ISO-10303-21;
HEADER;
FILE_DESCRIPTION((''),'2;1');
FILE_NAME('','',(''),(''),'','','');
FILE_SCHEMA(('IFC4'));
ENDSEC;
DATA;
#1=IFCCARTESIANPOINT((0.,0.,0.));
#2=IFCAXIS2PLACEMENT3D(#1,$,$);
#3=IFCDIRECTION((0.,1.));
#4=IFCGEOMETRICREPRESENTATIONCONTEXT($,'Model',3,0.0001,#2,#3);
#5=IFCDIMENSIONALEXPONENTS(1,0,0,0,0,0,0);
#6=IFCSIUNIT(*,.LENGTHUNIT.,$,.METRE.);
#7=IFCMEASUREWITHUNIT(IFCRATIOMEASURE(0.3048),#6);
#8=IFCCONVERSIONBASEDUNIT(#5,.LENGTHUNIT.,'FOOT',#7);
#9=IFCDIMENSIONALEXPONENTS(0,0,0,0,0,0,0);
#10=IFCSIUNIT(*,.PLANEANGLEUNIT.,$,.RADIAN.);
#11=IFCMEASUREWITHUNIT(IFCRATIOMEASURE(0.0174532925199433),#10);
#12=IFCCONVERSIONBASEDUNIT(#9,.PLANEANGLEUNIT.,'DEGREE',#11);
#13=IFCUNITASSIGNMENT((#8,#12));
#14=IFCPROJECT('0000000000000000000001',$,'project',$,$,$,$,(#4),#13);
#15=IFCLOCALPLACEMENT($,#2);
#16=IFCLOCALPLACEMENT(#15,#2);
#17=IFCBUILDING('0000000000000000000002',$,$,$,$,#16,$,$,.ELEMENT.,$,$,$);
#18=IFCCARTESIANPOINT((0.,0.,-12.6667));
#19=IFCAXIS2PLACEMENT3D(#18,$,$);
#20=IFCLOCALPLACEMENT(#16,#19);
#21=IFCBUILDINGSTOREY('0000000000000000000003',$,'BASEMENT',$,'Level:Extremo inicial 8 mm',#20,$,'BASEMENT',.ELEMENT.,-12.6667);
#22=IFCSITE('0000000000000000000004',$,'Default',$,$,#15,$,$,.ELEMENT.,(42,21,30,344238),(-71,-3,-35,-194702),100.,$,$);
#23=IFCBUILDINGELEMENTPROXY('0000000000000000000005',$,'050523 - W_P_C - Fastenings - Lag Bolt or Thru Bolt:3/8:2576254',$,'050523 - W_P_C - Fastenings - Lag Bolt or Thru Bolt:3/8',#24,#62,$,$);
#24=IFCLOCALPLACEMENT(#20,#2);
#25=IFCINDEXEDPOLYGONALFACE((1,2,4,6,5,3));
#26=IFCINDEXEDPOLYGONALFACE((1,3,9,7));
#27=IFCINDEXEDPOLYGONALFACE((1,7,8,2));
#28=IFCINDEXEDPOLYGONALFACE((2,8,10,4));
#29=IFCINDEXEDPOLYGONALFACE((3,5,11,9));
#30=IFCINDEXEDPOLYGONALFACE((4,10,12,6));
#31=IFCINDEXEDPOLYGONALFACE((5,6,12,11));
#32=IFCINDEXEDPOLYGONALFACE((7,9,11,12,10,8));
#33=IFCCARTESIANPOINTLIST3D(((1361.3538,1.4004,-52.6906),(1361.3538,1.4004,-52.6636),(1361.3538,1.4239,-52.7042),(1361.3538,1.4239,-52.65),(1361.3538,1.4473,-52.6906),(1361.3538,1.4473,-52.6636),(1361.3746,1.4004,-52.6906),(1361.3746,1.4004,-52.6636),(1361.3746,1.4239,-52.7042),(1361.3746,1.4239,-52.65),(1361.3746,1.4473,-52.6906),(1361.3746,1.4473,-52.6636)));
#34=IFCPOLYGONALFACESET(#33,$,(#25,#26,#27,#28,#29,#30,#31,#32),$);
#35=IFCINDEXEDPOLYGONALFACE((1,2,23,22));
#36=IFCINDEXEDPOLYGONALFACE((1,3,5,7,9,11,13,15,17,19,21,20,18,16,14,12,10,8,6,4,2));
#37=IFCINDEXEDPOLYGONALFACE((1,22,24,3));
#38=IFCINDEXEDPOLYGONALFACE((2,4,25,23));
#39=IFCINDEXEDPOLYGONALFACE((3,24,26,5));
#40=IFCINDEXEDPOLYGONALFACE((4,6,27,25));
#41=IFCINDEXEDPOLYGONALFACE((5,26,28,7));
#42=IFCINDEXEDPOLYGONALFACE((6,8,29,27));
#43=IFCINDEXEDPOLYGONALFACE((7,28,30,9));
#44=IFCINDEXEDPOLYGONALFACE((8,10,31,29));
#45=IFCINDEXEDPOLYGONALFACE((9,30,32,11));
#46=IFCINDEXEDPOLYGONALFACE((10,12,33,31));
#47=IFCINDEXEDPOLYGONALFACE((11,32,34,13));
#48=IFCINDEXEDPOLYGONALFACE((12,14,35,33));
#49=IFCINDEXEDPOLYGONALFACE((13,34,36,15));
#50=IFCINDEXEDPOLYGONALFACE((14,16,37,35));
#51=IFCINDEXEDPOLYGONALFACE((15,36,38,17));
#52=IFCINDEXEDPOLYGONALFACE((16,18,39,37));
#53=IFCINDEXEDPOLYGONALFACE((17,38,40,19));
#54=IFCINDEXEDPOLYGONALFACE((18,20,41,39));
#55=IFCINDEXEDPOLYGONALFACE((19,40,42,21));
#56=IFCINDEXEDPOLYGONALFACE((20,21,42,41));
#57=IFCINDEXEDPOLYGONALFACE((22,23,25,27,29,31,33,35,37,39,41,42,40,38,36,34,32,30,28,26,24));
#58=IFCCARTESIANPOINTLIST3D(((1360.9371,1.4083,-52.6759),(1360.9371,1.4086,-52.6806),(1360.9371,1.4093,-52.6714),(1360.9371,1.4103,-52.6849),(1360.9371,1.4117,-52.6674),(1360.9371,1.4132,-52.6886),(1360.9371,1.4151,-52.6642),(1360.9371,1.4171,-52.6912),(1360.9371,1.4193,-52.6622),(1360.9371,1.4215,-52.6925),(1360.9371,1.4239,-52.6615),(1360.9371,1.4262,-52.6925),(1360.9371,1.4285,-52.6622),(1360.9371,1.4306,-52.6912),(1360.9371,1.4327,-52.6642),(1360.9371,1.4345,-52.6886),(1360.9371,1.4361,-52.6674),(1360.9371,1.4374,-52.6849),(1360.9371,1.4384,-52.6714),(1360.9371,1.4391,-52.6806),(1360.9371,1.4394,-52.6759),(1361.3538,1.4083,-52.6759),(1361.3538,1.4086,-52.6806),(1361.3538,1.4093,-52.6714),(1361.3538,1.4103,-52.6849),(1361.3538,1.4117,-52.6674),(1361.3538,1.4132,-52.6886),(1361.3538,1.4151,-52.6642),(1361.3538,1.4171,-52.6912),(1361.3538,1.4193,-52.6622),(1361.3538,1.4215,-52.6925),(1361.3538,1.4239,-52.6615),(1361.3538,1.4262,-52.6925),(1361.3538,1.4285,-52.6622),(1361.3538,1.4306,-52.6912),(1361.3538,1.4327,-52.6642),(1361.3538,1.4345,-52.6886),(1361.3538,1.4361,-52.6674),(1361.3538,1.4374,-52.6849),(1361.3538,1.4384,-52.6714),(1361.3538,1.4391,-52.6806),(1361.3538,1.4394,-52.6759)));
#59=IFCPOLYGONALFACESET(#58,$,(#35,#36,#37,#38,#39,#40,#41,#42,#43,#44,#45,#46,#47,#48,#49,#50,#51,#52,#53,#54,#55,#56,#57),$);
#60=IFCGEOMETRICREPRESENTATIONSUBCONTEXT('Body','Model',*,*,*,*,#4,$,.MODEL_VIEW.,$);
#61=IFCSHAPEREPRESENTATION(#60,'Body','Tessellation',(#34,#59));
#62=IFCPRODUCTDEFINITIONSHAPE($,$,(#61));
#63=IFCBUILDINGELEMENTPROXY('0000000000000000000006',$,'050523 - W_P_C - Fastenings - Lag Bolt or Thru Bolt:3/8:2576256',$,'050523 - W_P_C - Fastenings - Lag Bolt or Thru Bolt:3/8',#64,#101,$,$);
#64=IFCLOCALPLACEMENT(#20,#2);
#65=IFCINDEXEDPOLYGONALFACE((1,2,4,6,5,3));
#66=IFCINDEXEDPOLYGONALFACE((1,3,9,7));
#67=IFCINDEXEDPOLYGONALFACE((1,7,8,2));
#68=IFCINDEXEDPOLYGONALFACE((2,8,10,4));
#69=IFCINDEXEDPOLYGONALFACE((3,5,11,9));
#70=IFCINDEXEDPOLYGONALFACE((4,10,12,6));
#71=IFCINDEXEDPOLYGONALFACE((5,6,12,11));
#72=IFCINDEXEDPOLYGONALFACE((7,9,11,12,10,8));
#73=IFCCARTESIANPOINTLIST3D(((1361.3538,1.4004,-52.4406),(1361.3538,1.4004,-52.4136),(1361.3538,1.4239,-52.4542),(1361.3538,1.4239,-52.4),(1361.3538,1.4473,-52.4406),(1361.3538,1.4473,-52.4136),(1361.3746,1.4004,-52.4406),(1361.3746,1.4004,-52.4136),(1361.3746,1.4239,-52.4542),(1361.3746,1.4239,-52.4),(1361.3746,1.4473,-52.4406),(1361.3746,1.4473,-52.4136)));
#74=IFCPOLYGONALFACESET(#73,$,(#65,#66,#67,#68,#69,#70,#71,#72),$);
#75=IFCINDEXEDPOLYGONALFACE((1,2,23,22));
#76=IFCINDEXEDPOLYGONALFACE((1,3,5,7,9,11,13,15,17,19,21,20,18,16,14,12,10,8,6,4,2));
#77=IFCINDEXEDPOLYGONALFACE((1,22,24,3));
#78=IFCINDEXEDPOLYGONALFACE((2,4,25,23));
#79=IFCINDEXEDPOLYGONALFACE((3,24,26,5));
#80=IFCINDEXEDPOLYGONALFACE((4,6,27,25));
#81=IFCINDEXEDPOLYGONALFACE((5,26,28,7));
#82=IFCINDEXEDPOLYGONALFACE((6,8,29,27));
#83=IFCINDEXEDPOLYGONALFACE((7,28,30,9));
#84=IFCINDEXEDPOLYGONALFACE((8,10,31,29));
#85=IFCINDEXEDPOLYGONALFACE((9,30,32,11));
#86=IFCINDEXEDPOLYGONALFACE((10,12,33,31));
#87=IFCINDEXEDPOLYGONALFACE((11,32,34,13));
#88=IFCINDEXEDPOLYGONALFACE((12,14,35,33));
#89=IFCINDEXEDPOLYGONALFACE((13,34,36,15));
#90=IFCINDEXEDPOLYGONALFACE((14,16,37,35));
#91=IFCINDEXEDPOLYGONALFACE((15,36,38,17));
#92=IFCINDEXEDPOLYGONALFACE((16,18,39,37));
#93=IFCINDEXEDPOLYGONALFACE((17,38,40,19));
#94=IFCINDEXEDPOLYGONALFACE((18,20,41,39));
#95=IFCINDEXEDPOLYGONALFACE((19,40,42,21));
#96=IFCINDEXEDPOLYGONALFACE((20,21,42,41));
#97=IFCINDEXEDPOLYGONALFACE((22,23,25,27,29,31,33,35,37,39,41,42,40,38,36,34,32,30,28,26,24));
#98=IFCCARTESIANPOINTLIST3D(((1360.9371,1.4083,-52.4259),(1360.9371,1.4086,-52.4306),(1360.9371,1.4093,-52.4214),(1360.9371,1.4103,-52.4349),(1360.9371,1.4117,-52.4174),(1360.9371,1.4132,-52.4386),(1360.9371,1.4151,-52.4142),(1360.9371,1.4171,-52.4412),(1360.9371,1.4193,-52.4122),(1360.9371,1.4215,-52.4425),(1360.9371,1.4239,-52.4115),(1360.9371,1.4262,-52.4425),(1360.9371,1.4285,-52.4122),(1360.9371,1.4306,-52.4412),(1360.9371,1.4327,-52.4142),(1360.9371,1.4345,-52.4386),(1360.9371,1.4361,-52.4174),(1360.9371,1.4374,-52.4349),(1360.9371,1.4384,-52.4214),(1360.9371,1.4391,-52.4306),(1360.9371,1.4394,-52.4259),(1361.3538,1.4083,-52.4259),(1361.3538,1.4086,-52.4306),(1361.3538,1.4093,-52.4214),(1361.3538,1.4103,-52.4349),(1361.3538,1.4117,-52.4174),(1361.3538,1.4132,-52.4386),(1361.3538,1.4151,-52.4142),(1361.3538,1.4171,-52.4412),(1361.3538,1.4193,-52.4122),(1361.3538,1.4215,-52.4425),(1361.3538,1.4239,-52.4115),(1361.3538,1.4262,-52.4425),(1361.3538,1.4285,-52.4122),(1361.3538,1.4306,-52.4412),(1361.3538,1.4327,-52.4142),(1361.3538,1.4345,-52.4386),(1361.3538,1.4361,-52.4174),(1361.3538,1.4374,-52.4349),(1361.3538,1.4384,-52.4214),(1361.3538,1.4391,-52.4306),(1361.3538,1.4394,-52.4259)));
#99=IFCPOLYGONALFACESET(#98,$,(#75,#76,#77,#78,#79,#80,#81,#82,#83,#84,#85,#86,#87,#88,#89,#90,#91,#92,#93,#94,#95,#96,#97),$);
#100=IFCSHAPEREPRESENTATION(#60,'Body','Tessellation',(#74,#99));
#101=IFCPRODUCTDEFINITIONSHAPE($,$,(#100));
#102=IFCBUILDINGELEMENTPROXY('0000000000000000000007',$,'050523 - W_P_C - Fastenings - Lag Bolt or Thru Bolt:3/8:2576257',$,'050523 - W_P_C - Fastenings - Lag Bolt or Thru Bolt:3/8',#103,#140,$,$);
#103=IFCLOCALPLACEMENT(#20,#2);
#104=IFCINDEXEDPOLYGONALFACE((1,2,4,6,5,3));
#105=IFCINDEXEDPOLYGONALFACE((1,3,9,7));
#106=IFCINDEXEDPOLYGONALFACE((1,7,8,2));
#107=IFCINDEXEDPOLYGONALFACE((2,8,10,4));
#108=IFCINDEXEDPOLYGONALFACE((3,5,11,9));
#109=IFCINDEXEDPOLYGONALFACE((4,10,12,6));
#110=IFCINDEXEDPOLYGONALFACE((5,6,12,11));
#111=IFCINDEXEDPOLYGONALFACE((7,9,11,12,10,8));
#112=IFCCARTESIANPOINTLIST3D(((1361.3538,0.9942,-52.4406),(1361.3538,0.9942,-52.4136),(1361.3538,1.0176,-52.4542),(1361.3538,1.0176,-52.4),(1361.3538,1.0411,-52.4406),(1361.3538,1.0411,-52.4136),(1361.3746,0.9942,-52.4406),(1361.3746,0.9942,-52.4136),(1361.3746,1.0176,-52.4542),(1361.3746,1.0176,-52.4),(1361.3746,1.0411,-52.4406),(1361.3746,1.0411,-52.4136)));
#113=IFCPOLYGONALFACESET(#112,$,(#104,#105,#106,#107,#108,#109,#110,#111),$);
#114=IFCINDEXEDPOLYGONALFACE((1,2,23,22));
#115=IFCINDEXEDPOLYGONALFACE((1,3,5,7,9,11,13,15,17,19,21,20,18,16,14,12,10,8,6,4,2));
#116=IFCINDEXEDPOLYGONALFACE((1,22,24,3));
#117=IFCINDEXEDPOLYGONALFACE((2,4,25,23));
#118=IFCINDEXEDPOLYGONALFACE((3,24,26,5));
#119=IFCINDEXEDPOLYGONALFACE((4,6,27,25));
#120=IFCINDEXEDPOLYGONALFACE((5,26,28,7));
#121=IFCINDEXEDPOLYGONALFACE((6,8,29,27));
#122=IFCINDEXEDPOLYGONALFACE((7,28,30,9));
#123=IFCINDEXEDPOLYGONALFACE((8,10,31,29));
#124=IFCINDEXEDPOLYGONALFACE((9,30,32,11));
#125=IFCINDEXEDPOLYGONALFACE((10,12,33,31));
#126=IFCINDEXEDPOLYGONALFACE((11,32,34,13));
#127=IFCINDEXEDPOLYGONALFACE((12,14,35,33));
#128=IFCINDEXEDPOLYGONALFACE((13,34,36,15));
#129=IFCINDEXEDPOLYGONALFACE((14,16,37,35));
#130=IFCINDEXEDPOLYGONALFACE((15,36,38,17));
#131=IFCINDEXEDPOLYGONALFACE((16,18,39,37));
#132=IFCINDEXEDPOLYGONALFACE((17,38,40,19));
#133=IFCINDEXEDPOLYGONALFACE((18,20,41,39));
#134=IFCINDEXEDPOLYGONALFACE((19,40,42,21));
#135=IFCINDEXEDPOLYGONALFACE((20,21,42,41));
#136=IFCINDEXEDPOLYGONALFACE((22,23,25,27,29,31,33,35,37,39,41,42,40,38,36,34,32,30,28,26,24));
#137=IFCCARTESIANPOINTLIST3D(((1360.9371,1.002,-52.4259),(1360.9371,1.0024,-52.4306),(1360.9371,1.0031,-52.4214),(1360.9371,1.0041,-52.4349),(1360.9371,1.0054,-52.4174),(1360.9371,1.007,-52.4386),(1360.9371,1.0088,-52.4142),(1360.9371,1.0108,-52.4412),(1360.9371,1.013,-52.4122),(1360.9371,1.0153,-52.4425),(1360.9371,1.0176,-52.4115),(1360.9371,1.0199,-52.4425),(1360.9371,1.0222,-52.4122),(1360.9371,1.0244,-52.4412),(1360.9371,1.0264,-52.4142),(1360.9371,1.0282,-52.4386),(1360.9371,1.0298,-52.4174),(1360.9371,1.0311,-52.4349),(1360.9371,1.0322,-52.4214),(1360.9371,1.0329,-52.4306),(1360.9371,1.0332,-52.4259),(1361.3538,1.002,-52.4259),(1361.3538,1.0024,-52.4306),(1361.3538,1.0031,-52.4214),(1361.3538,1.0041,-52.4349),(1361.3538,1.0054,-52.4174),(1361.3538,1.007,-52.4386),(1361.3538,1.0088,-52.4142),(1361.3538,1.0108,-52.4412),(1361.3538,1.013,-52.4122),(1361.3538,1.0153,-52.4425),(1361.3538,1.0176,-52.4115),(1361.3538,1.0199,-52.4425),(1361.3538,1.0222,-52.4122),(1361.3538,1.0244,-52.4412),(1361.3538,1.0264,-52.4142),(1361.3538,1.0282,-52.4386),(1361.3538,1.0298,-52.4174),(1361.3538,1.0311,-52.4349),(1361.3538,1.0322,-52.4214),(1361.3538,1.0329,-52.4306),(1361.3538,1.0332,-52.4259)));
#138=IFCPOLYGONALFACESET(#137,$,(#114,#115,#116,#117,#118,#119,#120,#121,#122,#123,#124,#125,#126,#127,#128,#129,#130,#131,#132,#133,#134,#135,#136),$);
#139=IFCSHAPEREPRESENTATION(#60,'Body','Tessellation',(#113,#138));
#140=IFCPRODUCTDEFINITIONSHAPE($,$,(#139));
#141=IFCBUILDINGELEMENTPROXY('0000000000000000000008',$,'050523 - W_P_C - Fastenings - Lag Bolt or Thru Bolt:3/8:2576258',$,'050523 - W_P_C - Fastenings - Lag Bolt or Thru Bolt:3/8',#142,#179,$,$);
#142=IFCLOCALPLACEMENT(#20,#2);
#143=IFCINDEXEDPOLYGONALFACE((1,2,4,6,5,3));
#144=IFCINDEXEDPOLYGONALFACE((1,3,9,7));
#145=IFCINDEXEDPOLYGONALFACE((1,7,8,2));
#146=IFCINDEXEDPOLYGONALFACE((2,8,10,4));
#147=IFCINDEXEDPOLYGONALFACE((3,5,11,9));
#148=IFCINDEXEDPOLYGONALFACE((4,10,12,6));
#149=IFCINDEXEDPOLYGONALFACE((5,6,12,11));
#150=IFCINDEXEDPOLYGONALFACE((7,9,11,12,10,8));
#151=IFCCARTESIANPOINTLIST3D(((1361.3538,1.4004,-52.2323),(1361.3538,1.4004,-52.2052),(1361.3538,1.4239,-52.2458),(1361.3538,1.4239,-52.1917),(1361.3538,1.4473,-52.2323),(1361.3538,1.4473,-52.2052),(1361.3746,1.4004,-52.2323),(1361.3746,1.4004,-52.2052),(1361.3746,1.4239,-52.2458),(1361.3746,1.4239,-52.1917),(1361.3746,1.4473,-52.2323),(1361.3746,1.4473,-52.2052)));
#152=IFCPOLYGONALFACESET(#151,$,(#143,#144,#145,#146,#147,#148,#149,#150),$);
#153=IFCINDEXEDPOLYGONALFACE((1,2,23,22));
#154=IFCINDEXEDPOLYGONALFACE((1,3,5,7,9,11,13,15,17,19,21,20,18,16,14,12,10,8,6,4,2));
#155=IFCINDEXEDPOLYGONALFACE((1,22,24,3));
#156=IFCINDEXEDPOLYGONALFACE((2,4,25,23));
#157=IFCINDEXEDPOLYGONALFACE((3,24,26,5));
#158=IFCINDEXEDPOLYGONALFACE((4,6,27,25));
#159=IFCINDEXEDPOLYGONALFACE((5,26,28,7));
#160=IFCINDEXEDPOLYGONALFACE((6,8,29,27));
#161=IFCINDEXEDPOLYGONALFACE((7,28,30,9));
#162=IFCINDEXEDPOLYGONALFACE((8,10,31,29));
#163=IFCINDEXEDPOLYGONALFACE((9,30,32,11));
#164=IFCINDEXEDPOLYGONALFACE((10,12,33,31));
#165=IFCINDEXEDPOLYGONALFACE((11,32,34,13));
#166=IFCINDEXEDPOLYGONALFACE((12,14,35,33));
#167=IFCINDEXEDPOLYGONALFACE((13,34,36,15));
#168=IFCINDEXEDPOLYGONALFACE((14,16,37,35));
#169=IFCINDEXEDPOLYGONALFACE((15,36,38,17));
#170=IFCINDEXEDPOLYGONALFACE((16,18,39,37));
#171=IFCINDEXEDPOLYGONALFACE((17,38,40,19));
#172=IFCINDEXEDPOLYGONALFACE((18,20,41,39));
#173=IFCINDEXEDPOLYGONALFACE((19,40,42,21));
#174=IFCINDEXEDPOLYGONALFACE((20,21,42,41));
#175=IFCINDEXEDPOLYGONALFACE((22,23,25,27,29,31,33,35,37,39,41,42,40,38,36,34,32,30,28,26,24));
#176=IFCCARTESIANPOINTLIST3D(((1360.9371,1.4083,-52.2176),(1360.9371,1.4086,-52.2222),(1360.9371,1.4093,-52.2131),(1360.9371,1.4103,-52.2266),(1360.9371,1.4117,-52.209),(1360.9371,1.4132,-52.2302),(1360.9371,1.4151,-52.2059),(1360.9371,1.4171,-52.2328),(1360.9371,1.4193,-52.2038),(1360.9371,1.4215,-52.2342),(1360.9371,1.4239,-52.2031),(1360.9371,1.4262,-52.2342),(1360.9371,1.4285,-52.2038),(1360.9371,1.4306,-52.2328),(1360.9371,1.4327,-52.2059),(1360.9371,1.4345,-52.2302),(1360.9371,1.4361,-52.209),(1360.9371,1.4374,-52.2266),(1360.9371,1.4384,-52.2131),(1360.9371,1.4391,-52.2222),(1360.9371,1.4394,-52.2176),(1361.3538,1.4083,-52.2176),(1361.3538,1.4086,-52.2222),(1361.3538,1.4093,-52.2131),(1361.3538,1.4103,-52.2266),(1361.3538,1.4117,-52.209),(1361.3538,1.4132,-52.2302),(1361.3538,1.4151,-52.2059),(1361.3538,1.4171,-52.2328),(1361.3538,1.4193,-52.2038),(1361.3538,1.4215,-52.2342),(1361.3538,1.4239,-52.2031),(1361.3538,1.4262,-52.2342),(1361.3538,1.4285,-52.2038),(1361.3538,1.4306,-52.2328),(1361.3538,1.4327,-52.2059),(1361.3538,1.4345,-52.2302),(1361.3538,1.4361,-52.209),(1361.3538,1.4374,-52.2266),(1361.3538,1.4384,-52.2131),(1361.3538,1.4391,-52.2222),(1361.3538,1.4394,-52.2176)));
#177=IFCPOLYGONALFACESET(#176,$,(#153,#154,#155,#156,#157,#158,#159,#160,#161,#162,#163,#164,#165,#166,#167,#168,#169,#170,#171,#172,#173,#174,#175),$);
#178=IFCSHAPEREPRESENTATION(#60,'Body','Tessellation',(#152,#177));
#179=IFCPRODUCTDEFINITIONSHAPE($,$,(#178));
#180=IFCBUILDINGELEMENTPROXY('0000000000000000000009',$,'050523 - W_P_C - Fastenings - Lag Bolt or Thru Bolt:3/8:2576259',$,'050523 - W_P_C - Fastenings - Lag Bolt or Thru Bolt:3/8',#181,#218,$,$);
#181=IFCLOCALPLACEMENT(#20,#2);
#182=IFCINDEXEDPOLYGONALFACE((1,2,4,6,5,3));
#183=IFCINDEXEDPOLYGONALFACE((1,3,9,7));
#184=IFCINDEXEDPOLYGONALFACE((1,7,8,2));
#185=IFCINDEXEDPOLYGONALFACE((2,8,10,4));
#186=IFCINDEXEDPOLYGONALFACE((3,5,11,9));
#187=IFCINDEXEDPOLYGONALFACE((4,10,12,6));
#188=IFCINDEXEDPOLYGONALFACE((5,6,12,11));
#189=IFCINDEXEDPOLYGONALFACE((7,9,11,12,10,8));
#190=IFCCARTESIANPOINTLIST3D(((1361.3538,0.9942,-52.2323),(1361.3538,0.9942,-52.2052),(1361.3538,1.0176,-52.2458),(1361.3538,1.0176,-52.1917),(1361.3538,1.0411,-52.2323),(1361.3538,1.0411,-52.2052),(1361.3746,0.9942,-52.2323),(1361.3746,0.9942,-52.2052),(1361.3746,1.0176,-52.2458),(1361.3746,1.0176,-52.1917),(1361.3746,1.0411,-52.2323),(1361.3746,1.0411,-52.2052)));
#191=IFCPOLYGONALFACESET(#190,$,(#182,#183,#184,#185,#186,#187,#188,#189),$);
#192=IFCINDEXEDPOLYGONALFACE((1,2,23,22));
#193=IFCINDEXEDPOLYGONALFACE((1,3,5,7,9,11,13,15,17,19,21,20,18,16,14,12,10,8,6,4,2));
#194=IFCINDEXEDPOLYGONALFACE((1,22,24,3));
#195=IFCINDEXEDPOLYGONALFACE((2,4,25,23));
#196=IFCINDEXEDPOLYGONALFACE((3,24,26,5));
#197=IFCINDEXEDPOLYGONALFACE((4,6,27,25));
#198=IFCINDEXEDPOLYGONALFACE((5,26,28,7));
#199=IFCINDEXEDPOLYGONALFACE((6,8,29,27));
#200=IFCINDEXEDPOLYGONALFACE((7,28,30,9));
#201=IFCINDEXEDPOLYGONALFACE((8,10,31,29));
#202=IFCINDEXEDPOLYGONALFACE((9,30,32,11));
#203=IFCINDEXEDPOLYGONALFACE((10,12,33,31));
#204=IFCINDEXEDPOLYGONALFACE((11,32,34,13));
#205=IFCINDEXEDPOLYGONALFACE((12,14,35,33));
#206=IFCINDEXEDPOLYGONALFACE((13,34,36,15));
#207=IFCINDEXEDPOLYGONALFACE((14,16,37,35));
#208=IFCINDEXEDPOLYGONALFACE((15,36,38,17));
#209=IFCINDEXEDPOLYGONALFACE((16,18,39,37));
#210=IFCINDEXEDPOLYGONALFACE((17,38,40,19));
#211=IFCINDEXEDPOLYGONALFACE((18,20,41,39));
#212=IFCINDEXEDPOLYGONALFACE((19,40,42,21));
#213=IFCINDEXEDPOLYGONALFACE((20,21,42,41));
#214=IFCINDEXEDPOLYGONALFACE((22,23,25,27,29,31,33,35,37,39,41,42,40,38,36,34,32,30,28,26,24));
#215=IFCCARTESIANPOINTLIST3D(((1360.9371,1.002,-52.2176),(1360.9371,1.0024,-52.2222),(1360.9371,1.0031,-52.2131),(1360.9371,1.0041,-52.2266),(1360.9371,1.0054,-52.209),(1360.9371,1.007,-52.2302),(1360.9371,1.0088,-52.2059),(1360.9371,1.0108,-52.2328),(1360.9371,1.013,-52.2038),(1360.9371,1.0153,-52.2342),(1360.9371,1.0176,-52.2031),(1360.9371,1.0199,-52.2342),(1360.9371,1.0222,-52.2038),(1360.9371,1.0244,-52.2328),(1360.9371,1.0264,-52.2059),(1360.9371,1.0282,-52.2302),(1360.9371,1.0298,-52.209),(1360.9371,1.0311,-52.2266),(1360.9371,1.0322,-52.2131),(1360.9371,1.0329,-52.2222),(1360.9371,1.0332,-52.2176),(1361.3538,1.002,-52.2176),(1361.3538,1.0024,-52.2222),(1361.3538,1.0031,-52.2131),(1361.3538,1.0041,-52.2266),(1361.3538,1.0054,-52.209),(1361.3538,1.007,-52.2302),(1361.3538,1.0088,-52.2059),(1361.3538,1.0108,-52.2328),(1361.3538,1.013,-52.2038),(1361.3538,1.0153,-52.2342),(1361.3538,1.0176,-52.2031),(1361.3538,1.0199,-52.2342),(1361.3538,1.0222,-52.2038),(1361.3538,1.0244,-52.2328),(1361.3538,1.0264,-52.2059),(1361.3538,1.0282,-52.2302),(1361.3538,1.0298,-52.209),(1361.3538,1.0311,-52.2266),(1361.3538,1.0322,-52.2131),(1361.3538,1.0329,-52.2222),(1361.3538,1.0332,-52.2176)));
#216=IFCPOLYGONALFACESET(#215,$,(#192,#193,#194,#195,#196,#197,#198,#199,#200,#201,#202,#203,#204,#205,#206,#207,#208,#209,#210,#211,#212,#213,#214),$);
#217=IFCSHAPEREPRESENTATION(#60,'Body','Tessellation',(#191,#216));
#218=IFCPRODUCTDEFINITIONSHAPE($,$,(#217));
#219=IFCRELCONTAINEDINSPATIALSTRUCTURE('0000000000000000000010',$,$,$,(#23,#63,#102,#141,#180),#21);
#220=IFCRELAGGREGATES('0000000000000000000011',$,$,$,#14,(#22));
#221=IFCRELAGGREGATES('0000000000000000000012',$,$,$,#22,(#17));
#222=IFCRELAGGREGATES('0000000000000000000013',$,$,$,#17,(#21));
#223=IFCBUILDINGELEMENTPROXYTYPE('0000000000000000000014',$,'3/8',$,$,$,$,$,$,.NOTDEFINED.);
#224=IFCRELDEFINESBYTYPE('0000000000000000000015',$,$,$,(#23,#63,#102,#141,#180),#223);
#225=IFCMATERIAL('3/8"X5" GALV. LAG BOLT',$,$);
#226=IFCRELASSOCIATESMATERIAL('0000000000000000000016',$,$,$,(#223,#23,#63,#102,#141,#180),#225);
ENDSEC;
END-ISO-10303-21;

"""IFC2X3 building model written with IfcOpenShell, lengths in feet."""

from ifc_helpers import new_model, entity, si_unit, converted_unit, direction, frame, frame_2d, origin, place, context, subcontext, project, spatial, polyline, circle, outline, extrude, source, transform, mapped, material, type_object, type_shapes, element, save


model = new_model("IFC2X3")

# Units and contexts
model_context = context("Model", 3, precision=0.0001, world=origin(), true_north=direction((0.0, 1.0)))
body_context = subcontext(model_context, "Body", "Model", "MODEL_VIEW")
ifc_project = project(units=[converted_unit("LENGTHUNIT", "FOOT", entity("IfcRatioMeasure", 0.3048), si_unit("LENGTHUNIT", "METRE"), dimensions=[1, 0, 0, 0, 0, 0, 0]), converted_unit("PLANEANGLEUNIT", "DEGREE", entity("IfcRatioMeasure", 0.0174532925199433), si_unit("PLANEANGLEUNIT", "RADIAN"), dimensions=[0, 0, 0, 0, 0, 0, 0])], contexts=[model_context])

# Site, building, storey
site_placement = place(None, origin())
site = spatial("IfcSite", under=ifc_project, at=site_placement, Name="Default", CompositionType="ELEMENT", RefLatitude=(42, 21, 30, 344238), RefLongitude=(-71, -3, -35, -194702), RefElevation=100.0)
building_placement = place(site_placement, origin())
building = spatial("IfcBuilding", under=site, at=building_placement, CompositionType="ELEMENT")
storey_placement = place(building_placement, frame((0.0, 0.0, -12.6667)))
storey = spatial("IfcBuildingStorey", under=building, at=storey_placement, Name="BASEMENT", ObjectType="Level:Extremo inicial 8 mm", LongName="BASEMENT", CompositionType="ELEMENT", Elevation=-12.6667)

# Building element proxies
ifc_material = material(Name="3/8\"X5\" GALV. LAG BOLT")
building_element_proxy_type = type_object("IfcBuildingElementProxyType", Name="3/8", PredefinedType="NOTDEFINED", material=ifc_material)
shared_shape = source(origin(), body_context, "Body", "SweptSolid", [
    extrude(outline(polyline([(-0.0135, -0.0234), (0.0135, -0.0234), (0.0271, 0.0), (0.0135, 0.0234), (-0.0135, 0.0234), (-0.0271, 0.0), (-0.0135, -0.0234)])), frame((0.0, 0.0, 0.0), z_axis=(0.0, 0.0, 1.0), x_axis=(0.0, -1.0, 0.0)), (0.0, 0.0, 1.0), 0.0208),
    extrude(circle(Radius=0.0156, at=frame_2d((0.0, 0.0), x_axis=(1.0, 0.0))), frame((0.0, 0.0, -0.4167), z_axis=(0.0, 0.0, 1.0), x_axis=(0.0, 1.0, 0.0)), (0.0, 0.0, 1.0), 0.4167),
])
type_shapes(building_element_proxy_type, [shared_shape])
for number, where, z_axis, x_axis, name in (
    (1, (1361.3538, 1.4239, -52.6771), (1.0, 0.0, 0.0), (0.0, 1.0, 0.0), "050523 - W_P_C - Fastenings - Lag Bolt or Thru Bolt:3/8:2576254"),
    (2, (1361.3538, 1.4239, -52.4271), (1.0, 0.0, 0.0), (0.0, 1.0, 0.0), "050523 - W_P_C - Fastenings - Lag Bolt or Thru Bolt:3/8:2576256"),
    (3, (1361.3538, 1.0176, -52.4271), (1.0, 0.0, 0.0), (0.0, 1.0, 0.0), "050523 - W_P_C - Fastenings - Lag Bolt or Thru Bolt:3/8:2576257"),
    (4, (1361.3538, 1.4239, -52.2188), (1.0, 0.0, 0.0), (0.0, 1.0, 0.0), "050523 - W_P_C - Fastenings - Lag Bolt or Thru Bolt:3/8:2576258"),
    (5, (1361.3538, 1.0176, -52.2188), (1.0, 0.0, 0.0), (0.0, 1.0, 0.0), "050523 - W_P_C - Fastenings - Lag Bolt or Thru Bolt:3/8:2576259"),
):
    element("IfcBuildingElementProxy", number, at=place(storey_placement, frame(where, z_axis=z_axis, x_axis=x_axis)), inside=storey, type_object=building_element_proxy_type, material=ifc_material, Name=name, ObjectType="050523 - W_P_C - Fastenings - Lag Bolt or Thru Bolt:3/8", context=body_context, shape_type="MappedRepresentation", body=[
        mapped(shared_shape, transform((0.0, 0.0, 0.0), scale=1.0)),
    ])

save(model, "model.ifc")
